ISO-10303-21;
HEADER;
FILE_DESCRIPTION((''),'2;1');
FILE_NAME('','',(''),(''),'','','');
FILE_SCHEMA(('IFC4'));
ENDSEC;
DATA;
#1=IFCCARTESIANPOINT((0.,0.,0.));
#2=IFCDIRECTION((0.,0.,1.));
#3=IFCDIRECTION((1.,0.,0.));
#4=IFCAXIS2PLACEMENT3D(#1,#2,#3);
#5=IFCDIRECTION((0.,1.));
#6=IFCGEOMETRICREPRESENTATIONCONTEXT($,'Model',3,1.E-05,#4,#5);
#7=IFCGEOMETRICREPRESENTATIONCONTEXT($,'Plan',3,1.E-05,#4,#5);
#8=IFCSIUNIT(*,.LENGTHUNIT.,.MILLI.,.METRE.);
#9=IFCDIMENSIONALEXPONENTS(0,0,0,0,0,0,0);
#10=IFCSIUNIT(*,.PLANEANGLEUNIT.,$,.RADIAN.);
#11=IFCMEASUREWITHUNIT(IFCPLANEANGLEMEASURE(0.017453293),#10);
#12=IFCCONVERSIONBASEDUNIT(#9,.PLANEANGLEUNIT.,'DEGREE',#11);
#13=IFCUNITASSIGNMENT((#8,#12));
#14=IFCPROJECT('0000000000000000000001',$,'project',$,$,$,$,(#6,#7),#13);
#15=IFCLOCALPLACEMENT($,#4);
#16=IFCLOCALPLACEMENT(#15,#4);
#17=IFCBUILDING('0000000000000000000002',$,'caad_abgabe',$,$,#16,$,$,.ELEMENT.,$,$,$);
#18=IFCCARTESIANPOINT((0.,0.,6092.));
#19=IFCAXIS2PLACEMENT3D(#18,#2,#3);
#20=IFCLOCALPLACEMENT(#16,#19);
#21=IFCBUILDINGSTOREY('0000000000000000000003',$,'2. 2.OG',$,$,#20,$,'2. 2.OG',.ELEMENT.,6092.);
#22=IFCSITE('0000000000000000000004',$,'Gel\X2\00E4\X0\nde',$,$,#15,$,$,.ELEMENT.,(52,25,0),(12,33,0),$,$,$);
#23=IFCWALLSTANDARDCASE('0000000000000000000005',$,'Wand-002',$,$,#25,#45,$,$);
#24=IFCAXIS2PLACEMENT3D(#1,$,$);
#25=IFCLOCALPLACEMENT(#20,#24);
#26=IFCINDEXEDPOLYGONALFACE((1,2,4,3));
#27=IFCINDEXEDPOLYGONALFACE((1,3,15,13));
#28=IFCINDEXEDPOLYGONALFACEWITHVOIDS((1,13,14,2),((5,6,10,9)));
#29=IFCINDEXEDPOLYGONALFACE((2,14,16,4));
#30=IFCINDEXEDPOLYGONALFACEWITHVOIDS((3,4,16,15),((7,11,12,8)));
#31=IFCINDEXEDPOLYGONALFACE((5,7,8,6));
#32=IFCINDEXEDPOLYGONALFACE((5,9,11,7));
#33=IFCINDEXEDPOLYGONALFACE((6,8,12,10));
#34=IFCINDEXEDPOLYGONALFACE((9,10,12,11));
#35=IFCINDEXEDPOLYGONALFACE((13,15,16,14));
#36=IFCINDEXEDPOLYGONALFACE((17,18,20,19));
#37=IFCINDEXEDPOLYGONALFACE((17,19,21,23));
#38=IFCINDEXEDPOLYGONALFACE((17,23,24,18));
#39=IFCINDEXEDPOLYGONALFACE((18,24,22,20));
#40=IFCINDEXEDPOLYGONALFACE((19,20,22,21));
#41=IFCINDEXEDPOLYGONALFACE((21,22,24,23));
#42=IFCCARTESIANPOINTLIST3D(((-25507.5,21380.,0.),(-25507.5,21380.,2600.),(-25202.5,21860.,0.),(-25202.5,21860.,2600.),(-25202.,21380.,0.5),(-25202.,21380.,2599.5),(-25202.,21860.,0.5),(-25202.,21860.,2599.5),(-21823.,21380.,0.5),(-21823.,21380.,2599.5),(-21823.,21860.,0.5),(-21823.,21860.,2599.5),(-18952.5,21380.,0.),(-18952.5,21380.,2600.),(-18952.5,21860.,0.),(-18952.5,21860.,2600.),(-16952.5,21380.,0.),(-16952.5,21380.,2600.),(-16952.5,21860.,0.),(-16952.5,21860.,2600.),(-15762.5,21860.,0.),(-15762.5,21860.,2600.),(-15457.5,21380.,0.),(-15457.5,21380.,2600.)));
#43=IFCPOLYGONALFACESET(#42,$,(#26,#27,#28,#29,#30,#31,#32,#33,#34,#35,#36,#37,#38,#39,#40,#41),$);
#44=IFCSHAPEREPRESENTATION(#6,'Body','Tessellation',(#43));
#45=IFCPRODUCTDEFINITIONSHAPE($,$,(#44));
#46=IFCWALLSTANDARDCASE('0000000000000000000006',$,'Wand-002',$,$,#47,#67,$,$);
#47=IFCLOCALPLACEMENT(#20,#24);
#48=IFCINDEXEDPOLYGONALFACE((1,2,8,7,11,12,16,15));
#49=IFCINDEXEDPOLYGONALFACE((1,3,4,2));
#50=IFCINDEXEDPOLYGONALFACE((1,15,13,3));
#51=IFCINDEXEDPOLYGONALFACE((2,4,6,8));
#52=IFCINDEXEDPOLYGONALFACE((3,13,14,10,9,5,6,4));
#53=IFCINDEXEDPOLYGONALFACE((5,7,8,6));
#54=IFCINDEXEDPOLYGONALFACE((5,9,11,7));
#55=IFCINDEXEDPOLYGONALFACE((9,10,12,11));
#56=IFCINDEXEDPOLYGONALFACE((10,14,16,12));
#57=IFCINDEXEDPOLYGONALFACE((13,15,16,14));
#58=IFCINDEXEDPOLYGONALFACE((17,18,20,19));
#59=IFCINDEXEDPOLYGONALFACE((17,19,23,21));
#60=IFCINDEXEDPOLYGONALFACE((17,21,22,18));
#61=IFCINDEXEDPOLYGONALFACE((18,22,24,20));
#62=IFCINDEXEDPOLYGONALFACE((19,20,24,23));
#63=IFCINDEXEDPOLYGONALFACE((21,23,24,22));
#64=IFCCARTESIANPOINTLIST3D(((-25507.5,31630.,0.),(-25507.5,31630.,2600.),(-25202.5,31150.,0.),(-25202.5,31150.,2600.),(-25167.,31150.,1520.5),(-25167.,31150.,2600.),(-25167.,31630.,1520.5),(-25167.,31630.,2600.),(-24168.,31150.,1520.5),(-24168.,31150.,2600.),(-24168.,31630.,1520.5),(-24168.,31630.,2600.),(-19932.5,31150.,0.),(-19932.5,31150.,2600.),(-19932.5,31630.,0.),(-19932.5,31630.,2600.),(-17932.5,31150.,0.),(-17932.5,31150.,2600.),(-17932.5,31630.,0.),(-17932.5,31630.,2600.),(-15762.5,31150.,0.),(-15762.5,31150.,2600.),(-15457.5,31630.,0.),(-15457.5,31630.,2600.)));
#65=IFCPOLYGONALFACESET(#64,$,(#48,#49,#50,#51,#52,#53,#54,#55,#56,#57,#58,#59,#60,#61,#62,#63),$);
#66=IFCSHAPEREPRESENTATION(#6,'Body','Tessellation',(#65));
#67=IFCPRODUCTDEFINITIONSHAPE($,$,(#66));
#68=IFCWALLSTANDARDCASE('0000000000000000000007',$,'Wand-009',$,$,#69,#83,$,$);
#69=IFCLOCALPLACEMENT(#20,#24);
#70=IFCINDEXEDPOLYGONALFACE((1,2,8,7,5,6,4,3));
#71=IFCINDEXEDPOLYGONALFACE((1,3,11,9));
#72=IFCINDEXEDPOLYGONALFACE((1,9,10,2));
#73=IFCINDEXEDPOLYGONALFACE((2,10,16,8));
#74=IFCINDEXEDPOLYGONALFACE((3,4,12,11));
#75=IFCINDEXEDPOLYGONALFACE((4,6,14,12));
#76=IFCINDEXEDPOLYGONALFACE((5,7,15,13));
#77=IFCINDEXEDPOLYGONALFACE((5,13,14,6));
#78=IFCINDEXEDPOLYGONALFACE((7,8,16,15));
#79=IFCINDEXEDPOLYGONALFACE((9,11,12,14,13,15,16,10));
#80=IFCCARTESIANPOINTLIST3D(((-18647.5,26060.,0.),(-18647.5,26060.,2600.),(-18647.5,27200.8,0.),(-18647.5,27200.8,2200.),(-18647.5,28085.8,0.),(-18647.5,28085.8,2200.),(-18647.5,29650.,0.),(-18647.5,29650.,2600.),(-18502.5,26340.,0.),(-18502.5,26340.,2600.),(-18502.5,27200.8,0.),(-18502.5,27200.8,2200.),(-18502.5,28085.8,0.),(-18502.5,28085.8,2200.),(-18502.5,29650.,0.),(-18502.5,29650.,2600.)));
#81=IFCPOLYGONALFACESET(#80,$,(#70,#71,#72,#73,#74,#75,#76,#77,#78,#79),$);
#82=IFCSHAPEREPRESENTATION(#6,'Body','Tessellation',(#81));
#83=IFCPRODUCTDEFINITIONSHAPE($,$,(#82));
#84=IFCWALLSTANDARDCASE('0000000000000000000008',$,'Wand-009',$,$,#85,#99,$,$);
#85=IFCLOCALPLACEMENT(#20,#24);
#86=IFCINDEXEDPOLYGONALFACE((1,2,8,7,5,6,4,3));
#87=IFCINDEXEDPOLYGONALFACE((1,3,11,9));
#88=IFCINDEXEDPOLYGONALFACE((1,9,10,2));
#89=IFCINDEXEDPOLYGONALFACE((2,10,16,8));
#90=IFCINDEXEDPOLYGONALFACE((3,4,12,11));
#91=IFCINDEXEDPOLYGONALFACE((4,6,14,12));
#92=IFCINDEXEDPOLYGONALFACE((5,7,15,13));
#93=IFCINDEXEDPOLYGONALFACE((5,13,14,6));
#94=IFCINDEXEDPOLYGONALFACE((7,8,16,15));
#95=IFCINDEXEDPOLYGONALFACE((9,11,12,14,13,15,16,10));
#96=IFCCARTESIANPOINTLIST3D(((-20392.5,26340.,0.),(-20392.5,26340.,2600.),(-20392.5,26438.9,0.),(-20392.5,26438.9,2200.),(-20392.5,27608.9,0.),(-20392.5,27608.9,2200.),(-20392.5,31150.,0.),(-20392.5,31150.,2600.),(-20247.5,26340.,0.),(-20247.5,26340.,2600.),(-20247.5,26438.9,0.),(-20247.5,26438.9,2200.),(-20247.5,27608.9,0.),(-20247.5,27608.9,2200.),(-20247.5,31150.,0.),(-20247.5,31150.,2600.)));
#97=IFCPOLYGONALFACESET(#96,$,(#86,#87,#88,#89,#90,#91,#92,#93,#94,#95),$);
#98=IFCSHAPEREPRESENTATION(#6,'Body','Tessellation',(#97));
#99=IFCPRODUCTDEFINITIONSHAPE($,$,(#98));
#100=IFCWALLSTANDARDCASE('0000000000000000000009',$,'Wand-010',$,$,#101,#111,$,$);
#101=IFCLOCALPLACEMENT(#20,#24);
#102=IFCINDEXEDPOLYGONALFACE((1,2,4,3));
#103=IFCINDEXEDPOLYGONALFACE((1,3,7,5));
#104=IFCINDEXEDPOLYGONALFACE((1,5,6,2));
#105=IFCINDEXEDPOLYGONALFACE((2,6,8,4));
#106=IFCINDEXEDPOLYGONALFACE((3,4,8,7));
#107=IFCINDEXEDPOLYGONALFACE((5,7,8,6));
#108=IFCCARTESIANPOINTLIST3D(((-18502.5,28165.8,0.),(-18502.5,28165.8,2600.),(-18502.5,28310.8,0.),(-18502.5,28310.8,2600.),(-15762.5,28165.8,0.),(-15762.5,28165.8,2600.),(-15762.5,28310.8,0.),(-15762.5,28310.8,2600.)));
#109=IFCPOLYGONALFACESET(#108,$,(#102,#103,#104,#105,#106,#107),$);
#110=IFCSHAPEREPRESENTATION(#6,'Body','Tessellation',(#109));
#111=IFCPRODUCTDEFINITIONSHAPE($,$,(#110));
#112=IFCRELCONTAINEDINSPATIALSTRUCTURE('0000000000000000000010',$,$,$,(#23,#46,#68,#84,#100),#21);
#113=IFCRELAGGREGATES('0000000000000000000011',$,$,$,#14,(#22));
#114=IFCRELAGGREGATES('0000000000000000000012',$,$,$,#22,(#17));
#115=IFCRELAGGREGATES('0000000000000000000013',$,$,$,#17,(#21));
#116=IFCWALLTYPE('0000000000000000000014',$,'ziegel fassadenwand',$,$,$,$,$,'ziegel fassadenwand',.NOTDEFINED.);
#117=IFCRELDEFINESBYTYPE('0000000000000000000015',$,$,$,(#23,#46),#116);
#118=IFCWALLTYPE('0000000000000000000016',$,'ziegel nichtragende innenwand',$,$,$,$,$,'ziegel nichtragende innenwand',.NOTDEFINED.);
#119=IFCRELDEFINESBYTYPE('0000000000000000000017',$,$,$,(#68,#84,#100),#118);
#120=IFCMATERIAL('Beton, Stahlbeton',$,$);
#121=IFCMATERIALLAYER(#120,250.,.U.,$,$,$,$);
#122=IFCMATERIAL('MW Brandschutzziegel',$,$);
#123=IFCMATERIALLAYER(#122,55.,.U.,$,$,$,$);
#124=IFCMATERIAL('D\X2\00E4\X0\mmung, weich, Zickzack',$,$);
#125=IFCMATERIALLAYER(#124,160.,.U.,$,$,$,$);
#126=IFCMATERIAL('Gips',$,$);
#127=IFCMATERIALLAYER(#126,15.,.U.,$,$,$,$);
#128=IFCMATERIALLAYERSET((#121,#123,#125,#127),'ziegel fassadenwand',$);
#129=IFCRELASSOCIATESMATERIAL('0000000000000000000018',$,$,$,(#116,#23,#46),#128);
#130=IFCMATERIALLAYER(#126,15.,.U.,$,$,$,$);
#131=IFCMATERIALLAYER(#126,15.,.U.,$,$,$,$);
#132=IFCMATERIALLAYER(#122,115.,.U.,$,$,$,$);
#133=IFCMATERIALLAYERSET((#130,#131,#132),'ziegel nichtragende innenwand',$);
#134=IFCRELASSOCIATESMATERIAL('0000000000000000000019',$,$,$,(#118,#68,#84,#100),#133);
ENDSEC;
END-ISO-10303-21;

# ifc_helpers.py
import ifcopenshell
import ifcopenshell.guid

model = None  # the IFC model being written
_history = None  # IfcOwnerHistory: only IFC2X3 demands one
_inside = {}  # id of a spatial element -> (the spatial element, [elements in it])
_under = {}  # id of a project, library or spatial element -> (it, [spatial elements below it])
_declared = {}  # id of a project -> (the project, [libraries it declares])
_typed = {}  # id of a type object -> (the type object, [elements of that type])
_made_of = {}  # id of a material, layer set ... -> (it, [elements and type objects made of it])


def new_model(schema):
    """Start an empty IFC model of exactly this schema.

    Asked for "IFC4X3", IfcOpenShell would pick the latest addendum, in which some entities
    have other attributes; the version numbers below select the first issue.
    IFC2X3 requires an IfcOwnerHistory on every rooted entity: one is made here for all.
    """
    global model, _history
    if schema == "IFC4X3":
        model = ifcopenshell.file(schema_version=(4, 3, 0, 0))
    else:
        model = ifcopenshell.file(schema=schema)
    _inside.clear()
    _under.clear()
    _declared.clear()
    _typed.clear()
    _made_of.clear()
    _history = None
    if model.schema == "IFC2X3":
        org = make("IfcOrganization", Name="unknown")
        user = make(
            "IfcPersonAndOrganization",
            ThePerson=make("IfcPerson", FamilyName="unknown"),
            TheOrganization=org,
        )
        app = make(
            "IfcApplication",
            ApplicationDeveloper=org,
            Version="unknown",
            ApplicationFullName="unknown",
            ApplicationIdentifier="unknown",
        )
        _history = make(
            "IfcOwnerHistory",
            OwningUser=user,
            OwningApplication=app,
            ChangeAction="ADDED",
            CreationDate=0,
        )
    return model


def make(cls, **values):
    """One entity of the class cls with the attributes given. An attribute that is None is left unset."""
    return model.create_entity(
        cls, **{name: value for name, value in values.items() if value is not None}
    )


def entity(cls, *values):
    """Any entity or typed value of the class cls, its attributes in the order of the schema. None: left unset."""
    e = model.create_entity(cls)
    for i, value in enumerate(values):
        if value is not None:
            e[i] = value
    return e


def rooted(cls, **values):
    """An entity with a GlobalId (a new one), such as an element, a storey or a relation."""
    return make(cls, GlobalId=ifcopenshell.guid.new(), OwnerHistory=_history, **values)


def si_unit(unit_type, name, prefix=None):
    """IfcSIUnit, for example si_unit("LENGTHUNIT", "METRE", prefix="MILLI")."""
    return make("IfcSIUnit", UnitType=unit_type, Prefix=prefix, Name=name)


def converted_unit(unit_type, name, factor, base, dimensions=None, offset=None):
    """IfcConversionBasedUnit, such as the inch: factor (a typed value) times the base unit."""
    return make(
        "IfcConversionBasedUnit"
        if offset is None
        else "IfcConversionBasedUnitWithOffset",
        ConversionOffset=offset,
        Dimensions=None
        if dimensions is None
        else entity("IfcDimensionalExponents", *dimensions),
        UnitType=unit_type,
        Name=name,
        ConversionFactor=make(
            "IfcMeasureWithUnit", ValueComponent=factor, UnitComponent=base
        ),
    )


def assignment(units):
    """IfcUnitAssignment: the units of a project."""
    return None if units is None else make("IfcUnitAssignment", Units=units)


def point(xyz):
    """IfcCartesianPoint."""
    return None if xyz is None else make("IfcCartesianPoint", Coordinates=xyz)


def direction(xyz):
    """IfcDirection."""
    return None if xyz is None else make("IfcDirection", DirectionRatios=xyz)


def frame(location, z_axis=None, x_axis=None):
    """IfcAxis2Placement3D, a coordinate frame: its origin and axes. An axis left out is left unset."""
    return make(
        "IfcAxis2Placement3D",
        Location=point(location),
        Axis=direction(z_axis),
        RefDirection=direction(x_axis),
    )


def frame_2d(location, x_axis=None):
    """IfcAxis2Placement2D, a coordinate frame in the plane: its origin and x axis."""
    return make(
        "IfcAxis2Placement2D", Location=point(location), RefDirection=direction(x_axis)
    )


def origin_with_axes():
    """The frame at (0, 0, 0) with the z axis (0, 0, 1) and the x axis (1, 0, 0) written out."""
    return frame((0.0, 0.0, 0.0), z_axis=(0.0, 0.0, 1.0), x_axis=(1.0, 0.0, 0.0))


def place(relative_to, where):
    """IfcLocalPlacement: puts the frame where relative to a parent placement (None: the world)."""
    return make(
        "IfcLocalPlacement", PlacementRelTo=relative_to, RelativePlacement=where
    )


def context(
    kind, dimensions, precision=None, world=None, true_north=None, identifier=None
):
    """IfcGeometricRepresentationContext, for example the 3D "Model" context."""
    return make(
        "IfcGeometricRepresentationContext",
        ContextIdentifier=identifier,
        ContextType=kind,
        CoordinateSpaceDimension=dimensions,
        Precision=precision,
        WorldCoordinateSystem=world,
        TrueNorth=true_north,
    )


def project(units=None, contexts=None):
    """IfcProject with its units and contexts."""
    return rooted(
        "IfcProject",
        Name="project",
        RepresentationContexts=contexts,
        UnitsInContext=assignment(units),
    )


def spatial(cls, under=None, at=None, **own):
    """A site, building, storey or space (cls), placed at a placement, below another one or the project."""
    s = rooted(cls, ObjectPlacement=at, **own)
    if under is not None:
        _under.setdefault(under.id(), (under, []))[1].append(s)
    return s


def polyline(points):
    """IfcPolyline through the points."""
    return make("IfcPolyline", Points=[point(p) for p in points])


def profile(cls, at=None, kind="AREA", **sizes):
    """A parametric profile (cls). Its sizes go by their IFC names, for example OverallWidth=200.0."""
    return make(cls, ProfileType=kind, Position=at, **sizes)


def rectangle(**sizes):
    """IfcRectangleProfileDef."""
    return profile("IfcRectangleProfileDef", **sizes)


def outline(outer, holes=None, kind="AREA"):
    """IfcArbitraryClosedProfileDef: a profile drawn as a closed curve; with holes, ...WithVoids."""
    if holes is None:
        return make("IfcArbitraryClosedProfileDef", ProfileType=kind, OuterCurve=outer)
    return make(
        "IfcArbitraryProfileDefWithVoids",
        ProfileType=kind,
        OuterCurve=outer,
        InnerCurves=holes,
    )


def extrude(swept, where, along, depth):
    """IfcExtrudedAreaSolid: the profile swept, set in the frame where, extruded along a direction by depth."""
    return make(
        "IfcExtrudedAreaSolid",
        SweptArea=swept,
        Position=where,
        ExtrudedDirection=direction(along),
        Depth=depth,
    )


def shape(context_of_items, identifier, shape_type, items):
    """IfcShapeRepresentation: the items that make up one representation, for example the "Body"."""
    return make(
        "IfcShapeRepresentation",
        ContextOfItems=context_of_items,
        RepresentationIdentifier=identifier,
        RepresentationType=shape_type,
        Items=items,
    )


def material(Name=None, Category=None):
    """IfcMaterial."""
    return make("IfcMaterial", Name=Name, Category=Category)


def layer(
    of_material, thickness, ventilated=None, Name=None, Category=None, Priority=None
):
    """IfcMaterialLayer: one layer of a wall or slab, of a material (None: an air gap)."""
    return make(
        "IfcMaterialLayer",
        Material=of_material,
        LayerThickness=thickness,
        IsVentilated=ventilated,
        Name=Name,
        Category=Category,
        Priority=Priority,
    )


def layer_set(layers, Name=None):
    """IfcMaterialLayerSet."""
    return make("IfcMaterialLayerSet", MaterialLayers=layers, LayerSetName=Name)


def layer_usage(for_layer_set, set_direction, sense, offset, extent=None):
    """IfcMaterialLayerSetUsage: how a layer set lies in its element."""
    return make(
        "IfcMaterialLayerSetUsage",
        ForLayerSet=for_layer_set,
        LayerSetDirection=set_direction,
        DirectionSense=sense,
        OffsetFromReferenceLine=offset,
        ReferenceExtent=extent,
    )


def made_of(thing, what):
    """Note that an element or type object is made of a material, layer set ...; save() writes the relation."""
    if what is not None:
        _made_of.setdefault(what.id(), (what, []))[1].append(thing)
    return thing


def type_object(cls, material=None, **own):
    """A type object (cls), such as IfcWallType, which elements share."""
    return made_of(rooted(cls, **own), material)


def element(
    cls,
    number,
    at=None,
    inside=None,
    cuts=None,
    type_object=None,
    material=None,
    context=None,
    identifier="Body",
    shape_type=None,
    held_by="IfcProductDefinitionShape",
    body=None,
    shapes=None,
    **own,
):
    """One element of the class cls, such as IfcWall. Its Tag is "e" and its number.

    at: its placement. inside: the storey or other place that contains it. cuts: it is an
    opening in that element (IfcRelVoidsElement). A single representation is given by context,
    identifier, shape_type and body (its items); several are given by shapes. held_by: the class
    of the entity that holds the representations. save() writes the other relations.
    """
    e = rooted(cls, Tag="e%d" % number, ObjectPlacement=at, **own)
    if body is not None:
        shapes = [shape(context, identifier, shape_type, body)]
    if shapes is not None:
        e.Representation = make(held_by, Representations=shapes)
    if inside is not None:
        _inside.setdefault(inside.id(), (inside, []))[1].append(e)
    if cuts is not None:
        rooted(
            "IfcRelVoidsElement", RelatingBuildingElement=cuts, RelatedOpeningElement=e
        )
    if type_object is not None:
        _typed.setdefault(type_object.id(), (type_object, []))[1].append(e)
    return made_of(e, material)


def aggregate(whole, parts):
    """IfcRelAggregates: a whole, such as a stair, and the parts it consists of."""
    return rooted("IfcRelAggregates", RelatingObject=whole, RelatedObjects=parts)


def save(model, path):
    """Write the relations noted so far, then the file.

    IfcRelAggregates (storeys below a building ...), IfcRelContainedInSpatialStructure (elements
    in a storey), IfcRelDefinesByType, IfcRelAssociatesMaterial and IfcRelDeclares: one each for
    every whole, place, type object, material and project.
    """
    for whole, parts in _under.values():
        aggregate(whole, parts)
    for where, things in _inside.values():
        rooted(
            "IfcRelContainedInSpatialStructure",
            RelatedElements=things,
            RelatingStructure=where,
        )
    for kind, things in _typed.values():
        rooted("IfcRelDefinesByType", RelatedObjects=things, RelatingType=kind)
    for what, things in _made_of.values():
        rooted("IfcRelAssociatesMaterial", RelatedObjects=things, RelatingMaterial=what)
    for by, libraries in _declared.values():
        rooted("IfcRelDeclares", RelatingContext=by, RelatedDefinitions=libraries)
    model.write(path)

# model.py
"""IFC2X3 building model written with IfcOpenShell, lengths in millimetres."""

from ifc_helpers import new_model, entity, si_unit, converted_unit, direction, frame, frame_2d, origin_with_axes, place, context, project, spatial, polyline, rectangle, outline, extrude, material, layer, layer_set, layer_usage, type_object, element, save


model = new_model("IFC2X3")

# Units and contexts
model_context = context("Model", 3, precision=1e-05, world=origin_with_axes(), true_north=direction((0.0, 1.0)))
plan_context = context("Plan", 3, precision=1e-05, world=origin_with_axes(), true_north=direction((0.0, 1.0)))
ifc_project = project(units=[si_unit("LENGTHUNIT", "METRE", prefix="MILLI"), converted_unit("PLANEANGLEUNIT", "DEGREE", entity("IfcPlaneAngleMeasure", 0.017453293), si_unit("PLANEANGLEUNIT", "RADIAN"), dimensions=[0, 0, 0, 0, 0, 0, 0])], contexts=[model_context, plan_context])

# Site, building, storey
site_placement = place(None, origin_with_axes())
site = spatial("IfcSite", under=ifc_project, at=site_placement, Name="Gelände", CompositionType="ELEMENT", RefLatitude=(52, 25, 0), RefLongitude=(12, 33, 0))
building_placement = place(site_placement, origin_with_axes())
building = spatial("IfcBuilding", under=site, at=building_placement, Name="caad_abgabe", CompositionType="ELEMENT")
storey_placement = place(building_placement, frame((0.0, 0.0, 6092.0), z_axis=(0.0, 0.0, 1.0), x_axis=(1.0, 0.0, 0.0)))
storey = spatial("IfcBuildingStorey", under=building, at=storey_placement, Name="2. 2.OG", LongName="2. 2.OG", CompositionType="ELEMENT", Elevation=6092.0)

# Shared definitions
ifc_material_1 = material(Name="Gips")
ifc_material_2 = material(Name="Beton, Stahlbeton")

# Walls, openings
ifc_layer_1 = layer(ifc_material_2, 250.0, ventilated="UNKNOWN")
ifc_material_3 = material(Name="MW Brandschutzziegel")
ifc_layer_2 = layer(ifc_material_3, 55.0, ventilated="UNKNOWN")
ifc_material_4 = material(Name="Dämmung, weich, Zickzack")
ifc_layer_3 = layer(ifc_material_4, 160.0, ventilated="UNKNOWN")
ifc_layer_4 = layer(ifc_material_1, 15.0, ventilated="UNKNOWN")
ifc_layer_set_1 = layer_set([ifc_layer_1, ifc_layer_2, ifc_layer_3, ifc_layer_4], Name="ziegel fassadenwand")
ifc_layer_usage_1 = layer_usage(ifc_layer_set_1, "AXIS2", "POSITIVE", 0.0)
wall_type_1 = type_object("IfcWallType", Name="ziegel fassadenwand", ElementType="ziegel fassadenwand", PredefinedType="NOTDEFINED", material=ifc_layer_set_1)
wall_1_placement = place(storey_placement, frame((-25507.5, 21380.0, 0.0), z_axis=(0.0, 0.0, 1.0), x_axis=(1.0, 0.0, 0.0)))
wall_1 = element("IfcWallStandardCase", 1, at=wall_1_placement, inside=storey, type_object=wall_type_1, material=ifc_layer_usage_1, Name="Wand-002", context=model_context, shape_type="SweptSolid", body=[
    extrude(outline(polyline([(0.0, 0.0), (10050.0, 0.0), (9745.0, 480.0), (305.0, 480.0), (0.0, 0.0)])), origin_with_axes(), (0.0, 0.0, 1.0), 2600.0),
])
opening_1_placement = place(wall_1_placement, frame((1995.0, 0.0, 0.0), z_axis=(0.0, 0.0, 1.0), x_axis=(1.0, 0.0, 0.0)))
element("IfcOpeningElement", 2, at=opening_1_placement, cuts=wall_1, ObjectType="Opening", context=model_context, shape_type="SweptSolid", body=[
    extrude(rectangle(XDim=3379.0, YDim=2599.0, at=frame_2d((0.0, 1300.0), x_axis=(1.0, 0.0))), frame((0.0, 0.0, 0.0), z_axis=(0.0, 1.0, 0.0), x_axis=(-1.0, 0.0, 0.0)), (0.0, 0.0, 1.0), 480.0),
])
opening_2_placement = place(wall_1_placement, frame((7555.0, 0.0, 0.0), z_axis=(0.0, 0.0, 1.0), x_axis=(1.0, 0.0, 0.0)))
element("IfcOpeningElement", 3, at=opening_2_placement, cuts=wall_1, ObjectType="Opening", context=model_context, shape_type="SweptSolid", body=[
    extrude(rectangle(XDim=2000.0, YDim=2600.0, at=frame_2d((0.0, 1300.0), x_axis=(1.0, 0.0))), frame((0.0, 0.0, 0.0), z_axis=(0.0, 1.0, 0.0), x_axis=(-1.0, 0.0, 0.0)), (0.0, 0.0, 1.0), 480.0),
])
ifc_layer_usage_2 = layer_usage(ifc_layer_set_1, "AXIS2", "NEGATIVE", 0.0)
wall_2_placement = place(storey_placement, frame((-25507.5, 31630.0, 0.0), z_axis=(0.0, 0.0, 1.0), x_axis=(1.0, 0.0, 0.0)))
wall_2 = element("IfcWallStandardCase", 4, at=wall_2_placement, inside=storey, type_object=wall_type_1, material=ifc_layer_usage_2, Name="Wand-002", context=model_context, shape_type="SweptSolid", body=[
    extrude(outline(polyline([(305.0, -480.0), (9745.0, -480.0), (10050.0, 0.0), (0.0, 0.0), (305.0, -480.0)])), origin_with_axes(), (0.0, 0.0, 1.0), 2600.0),
])
opening_3_placement = place(wall_2_placement, frame((6575.0, -480.0, 0.0), z_axis=(0.0, 0.0, 1.0), x_axis=(1.0, 0.0, 0.0)))
element("IfcOpeningElement", 5, at=opening_3_placement, cuts=wall_2, ObjectType="Opening", context=model_context, shape_type="SweptSolid", body=[
    extrude(rectangle(XDim=2000.0, YDim=2600.0, at=frame_2d((0.0, 1300.0), x_axis=(1.0, 0.0))), frame((0.0, 0.0, 0.0), z_axis=(0.0, 1.0, 0.0), x_axis=(-1.0, 0.0, 0.0)), (0.0, 0.0, 1.0), 480.0),
])
opening_4_placement = place(wall_2_placement, frame((840.0, -480.0, 1520.0), z_axis=(0.0, 0.0, 1.0), x_axis=(1.0, 0.0, 0.0)))
element("IfcOpeningElement", 6, at=opening_4_placement, cuts=wall_2, ObjectType="Opening", context=model_context, shape_type="SweptSolid", body=[
    extrude(rectangle(XDim=999.0, YDim=1525.0, at=frame_2d((0.0, 763.0), x_axis=(1.0, 0.0))), frame((0.0, 0.0, 0.0), z_axis=(0.0, 1.0, 0.0), x_axis=(-1.0, 0.0, 0.0)), (0.0, 0.0, 1.0), 480.0),
])

# Walls, openings
ifc_layer_5 = layer(ifc_material_1, 15.0, ventilated="UNKNOWN")
ifc_layer_6 = layer(ifc_material_1, 15.0, ventilated="UNKNOWN")
ifc_layer_7 = layer(ifc_material_3, 115.0, ventilated="UNKNOWN")
ifc_layer_set_2 = layer_set([ifc_layer_5, ifc_layer_6, ifc_layer_7], Name="ziegel nichtragende innenwand")
ifc_layer_usage_3 = layer_usage(ifc_layer_set_2, "AXIS2", "NEGATIVE", 0.0)
wall_type_2 = type_object("IfcWallType", Name="ziegel nichtragende innenwand", ElementType="ziegel nichtragende innenwand", PredefinedType="NOTDEFINED", material=ifc_layer_set_2)
wall_3_placement = place(storey_placement, frame((-18647.5, 26340.0, 0.0), z_axis=(0.0, 0.0, 1.0), x_axis=(0.0, 1.0, 0.0)))
wall_3 = element("IfcWallStandardCase", 7, at=wall_3_placement, inside=storey, type_object=wall_type_2, material=ifc_layer_usage_3, Name="Wand-009", context=model_context, shape_type="SweptSolid", body=[
    extrude(outline(polyline([(0.0, -145.0), (3310.0, -145.0), (3310.0, 0.0), (-280.0, 0.0), (0.0, -145.0)])), origin_with_axes(), (0.0, 0.0, 1.0), 2600.0),
])
opening_5_placement = place(wall_3_placement, frame((1303.2, -145.0, 0.0), z_axis=(0.0, 0.0, 1.0), x_axis=(1.0, 0.0, 0.0)))
element("IfcOpeningElement", 8, at=opening_5_placement, cuts=wall_3, ObjectType="Opening", context=model_context, shape_type="SweptSolid", body=[
    extrude(rectangle(XDim=885.0, YDim=2200.0, at=frame_2d((0.0, 1100.0), x_axis=(-1.0, 0.0))), frame((0.0, 0.0, 0.0), z_axis=(0.0, 1.0, 0.0), x_axis=(-1.0, 0.0, 0.0)), (0.0, 0.0, 1.0), 145.0),
])
ifc_layer_usage_4 = layer_usage(ifc_layer_set_2, "AXIS2", "POSITIVE", 0.0)
wall_4_placement = place(storey_placement, frame((-20392.5, 31150.0, 0.0), z_axis=(0.0, 0.0, 1.0), x_axis=(0.0, -1.0, 0.0)))
wall_4 = element("IfcWallStandardCase", 9, at=wall_4_placement, inside=storey, type_object=wall_type_2, material=ifc_layer_usage_4, Name="Wand-009", context=model_context, shape_type="SweptSolid", body=[
    extrude(outline(polyline([(0.0, 0.0), (4810.0, 0.0), (4810.0, 145.0), (0.0, 145.0), (0.0, 0.0)])), origin_with_axes(), (0.0, 0.0, 1.0), 2600.0),
])
opening_6_placement = place(wall_4_placement, frame((4126.2, 0.0, 0.0), z_axis=(0.0, 0.0, 1.0), x_axis=(1.0, 0.0, 0.0)))
element("IfcOpeningElement", 10, at=opening_6_placement, cuts=wall_4, ObjectType="Opening", context=model_context, shape_type="SweptSolid", body=[
    extrude(rectangle(XDim=1170.0, YDim=2200.0, at=frame_2d((0.0, 1100.0), x_axis=(-1.0, 0.0))), frame((0.0, 0.0, 0.0), z_axis=(0.0, 1.0, 0.0), x_axis=(-1.0, 0.0, 0.0)), (0.0, 0.0, 1.0), 145.0),
])

# Wall
ifc_layer_usage_5 = layer_usage(ifc_layer_set_2, "AXIS2", "NEGATIVE", 72.5)
wall_5_placement = place(storey_placement, frame((-18647.5, 28238.3, 0.0), z_axis=(0.0, 0.0, 1.0), x_axis=(1.0, 0.0, 0.0)))
element("IfcWallStandardCase", 11, at=wall_5_placement, inside=storey, type_object=wall_type_2, material=ifc_layer_usage_5, Name="Wand-010", context=model_context, shape_type="SweptSolid", body=[
    extrude(outline(polyline([(145.0, -72.5), (2885.0, -72.5), (2885.0, 72.5), (145.0, 72.5), (145.0, -72.5)])), origin_with_axes(), (0.0, 0.0, 1.0), 2600.0),
])

save(model, "model.ifc")
